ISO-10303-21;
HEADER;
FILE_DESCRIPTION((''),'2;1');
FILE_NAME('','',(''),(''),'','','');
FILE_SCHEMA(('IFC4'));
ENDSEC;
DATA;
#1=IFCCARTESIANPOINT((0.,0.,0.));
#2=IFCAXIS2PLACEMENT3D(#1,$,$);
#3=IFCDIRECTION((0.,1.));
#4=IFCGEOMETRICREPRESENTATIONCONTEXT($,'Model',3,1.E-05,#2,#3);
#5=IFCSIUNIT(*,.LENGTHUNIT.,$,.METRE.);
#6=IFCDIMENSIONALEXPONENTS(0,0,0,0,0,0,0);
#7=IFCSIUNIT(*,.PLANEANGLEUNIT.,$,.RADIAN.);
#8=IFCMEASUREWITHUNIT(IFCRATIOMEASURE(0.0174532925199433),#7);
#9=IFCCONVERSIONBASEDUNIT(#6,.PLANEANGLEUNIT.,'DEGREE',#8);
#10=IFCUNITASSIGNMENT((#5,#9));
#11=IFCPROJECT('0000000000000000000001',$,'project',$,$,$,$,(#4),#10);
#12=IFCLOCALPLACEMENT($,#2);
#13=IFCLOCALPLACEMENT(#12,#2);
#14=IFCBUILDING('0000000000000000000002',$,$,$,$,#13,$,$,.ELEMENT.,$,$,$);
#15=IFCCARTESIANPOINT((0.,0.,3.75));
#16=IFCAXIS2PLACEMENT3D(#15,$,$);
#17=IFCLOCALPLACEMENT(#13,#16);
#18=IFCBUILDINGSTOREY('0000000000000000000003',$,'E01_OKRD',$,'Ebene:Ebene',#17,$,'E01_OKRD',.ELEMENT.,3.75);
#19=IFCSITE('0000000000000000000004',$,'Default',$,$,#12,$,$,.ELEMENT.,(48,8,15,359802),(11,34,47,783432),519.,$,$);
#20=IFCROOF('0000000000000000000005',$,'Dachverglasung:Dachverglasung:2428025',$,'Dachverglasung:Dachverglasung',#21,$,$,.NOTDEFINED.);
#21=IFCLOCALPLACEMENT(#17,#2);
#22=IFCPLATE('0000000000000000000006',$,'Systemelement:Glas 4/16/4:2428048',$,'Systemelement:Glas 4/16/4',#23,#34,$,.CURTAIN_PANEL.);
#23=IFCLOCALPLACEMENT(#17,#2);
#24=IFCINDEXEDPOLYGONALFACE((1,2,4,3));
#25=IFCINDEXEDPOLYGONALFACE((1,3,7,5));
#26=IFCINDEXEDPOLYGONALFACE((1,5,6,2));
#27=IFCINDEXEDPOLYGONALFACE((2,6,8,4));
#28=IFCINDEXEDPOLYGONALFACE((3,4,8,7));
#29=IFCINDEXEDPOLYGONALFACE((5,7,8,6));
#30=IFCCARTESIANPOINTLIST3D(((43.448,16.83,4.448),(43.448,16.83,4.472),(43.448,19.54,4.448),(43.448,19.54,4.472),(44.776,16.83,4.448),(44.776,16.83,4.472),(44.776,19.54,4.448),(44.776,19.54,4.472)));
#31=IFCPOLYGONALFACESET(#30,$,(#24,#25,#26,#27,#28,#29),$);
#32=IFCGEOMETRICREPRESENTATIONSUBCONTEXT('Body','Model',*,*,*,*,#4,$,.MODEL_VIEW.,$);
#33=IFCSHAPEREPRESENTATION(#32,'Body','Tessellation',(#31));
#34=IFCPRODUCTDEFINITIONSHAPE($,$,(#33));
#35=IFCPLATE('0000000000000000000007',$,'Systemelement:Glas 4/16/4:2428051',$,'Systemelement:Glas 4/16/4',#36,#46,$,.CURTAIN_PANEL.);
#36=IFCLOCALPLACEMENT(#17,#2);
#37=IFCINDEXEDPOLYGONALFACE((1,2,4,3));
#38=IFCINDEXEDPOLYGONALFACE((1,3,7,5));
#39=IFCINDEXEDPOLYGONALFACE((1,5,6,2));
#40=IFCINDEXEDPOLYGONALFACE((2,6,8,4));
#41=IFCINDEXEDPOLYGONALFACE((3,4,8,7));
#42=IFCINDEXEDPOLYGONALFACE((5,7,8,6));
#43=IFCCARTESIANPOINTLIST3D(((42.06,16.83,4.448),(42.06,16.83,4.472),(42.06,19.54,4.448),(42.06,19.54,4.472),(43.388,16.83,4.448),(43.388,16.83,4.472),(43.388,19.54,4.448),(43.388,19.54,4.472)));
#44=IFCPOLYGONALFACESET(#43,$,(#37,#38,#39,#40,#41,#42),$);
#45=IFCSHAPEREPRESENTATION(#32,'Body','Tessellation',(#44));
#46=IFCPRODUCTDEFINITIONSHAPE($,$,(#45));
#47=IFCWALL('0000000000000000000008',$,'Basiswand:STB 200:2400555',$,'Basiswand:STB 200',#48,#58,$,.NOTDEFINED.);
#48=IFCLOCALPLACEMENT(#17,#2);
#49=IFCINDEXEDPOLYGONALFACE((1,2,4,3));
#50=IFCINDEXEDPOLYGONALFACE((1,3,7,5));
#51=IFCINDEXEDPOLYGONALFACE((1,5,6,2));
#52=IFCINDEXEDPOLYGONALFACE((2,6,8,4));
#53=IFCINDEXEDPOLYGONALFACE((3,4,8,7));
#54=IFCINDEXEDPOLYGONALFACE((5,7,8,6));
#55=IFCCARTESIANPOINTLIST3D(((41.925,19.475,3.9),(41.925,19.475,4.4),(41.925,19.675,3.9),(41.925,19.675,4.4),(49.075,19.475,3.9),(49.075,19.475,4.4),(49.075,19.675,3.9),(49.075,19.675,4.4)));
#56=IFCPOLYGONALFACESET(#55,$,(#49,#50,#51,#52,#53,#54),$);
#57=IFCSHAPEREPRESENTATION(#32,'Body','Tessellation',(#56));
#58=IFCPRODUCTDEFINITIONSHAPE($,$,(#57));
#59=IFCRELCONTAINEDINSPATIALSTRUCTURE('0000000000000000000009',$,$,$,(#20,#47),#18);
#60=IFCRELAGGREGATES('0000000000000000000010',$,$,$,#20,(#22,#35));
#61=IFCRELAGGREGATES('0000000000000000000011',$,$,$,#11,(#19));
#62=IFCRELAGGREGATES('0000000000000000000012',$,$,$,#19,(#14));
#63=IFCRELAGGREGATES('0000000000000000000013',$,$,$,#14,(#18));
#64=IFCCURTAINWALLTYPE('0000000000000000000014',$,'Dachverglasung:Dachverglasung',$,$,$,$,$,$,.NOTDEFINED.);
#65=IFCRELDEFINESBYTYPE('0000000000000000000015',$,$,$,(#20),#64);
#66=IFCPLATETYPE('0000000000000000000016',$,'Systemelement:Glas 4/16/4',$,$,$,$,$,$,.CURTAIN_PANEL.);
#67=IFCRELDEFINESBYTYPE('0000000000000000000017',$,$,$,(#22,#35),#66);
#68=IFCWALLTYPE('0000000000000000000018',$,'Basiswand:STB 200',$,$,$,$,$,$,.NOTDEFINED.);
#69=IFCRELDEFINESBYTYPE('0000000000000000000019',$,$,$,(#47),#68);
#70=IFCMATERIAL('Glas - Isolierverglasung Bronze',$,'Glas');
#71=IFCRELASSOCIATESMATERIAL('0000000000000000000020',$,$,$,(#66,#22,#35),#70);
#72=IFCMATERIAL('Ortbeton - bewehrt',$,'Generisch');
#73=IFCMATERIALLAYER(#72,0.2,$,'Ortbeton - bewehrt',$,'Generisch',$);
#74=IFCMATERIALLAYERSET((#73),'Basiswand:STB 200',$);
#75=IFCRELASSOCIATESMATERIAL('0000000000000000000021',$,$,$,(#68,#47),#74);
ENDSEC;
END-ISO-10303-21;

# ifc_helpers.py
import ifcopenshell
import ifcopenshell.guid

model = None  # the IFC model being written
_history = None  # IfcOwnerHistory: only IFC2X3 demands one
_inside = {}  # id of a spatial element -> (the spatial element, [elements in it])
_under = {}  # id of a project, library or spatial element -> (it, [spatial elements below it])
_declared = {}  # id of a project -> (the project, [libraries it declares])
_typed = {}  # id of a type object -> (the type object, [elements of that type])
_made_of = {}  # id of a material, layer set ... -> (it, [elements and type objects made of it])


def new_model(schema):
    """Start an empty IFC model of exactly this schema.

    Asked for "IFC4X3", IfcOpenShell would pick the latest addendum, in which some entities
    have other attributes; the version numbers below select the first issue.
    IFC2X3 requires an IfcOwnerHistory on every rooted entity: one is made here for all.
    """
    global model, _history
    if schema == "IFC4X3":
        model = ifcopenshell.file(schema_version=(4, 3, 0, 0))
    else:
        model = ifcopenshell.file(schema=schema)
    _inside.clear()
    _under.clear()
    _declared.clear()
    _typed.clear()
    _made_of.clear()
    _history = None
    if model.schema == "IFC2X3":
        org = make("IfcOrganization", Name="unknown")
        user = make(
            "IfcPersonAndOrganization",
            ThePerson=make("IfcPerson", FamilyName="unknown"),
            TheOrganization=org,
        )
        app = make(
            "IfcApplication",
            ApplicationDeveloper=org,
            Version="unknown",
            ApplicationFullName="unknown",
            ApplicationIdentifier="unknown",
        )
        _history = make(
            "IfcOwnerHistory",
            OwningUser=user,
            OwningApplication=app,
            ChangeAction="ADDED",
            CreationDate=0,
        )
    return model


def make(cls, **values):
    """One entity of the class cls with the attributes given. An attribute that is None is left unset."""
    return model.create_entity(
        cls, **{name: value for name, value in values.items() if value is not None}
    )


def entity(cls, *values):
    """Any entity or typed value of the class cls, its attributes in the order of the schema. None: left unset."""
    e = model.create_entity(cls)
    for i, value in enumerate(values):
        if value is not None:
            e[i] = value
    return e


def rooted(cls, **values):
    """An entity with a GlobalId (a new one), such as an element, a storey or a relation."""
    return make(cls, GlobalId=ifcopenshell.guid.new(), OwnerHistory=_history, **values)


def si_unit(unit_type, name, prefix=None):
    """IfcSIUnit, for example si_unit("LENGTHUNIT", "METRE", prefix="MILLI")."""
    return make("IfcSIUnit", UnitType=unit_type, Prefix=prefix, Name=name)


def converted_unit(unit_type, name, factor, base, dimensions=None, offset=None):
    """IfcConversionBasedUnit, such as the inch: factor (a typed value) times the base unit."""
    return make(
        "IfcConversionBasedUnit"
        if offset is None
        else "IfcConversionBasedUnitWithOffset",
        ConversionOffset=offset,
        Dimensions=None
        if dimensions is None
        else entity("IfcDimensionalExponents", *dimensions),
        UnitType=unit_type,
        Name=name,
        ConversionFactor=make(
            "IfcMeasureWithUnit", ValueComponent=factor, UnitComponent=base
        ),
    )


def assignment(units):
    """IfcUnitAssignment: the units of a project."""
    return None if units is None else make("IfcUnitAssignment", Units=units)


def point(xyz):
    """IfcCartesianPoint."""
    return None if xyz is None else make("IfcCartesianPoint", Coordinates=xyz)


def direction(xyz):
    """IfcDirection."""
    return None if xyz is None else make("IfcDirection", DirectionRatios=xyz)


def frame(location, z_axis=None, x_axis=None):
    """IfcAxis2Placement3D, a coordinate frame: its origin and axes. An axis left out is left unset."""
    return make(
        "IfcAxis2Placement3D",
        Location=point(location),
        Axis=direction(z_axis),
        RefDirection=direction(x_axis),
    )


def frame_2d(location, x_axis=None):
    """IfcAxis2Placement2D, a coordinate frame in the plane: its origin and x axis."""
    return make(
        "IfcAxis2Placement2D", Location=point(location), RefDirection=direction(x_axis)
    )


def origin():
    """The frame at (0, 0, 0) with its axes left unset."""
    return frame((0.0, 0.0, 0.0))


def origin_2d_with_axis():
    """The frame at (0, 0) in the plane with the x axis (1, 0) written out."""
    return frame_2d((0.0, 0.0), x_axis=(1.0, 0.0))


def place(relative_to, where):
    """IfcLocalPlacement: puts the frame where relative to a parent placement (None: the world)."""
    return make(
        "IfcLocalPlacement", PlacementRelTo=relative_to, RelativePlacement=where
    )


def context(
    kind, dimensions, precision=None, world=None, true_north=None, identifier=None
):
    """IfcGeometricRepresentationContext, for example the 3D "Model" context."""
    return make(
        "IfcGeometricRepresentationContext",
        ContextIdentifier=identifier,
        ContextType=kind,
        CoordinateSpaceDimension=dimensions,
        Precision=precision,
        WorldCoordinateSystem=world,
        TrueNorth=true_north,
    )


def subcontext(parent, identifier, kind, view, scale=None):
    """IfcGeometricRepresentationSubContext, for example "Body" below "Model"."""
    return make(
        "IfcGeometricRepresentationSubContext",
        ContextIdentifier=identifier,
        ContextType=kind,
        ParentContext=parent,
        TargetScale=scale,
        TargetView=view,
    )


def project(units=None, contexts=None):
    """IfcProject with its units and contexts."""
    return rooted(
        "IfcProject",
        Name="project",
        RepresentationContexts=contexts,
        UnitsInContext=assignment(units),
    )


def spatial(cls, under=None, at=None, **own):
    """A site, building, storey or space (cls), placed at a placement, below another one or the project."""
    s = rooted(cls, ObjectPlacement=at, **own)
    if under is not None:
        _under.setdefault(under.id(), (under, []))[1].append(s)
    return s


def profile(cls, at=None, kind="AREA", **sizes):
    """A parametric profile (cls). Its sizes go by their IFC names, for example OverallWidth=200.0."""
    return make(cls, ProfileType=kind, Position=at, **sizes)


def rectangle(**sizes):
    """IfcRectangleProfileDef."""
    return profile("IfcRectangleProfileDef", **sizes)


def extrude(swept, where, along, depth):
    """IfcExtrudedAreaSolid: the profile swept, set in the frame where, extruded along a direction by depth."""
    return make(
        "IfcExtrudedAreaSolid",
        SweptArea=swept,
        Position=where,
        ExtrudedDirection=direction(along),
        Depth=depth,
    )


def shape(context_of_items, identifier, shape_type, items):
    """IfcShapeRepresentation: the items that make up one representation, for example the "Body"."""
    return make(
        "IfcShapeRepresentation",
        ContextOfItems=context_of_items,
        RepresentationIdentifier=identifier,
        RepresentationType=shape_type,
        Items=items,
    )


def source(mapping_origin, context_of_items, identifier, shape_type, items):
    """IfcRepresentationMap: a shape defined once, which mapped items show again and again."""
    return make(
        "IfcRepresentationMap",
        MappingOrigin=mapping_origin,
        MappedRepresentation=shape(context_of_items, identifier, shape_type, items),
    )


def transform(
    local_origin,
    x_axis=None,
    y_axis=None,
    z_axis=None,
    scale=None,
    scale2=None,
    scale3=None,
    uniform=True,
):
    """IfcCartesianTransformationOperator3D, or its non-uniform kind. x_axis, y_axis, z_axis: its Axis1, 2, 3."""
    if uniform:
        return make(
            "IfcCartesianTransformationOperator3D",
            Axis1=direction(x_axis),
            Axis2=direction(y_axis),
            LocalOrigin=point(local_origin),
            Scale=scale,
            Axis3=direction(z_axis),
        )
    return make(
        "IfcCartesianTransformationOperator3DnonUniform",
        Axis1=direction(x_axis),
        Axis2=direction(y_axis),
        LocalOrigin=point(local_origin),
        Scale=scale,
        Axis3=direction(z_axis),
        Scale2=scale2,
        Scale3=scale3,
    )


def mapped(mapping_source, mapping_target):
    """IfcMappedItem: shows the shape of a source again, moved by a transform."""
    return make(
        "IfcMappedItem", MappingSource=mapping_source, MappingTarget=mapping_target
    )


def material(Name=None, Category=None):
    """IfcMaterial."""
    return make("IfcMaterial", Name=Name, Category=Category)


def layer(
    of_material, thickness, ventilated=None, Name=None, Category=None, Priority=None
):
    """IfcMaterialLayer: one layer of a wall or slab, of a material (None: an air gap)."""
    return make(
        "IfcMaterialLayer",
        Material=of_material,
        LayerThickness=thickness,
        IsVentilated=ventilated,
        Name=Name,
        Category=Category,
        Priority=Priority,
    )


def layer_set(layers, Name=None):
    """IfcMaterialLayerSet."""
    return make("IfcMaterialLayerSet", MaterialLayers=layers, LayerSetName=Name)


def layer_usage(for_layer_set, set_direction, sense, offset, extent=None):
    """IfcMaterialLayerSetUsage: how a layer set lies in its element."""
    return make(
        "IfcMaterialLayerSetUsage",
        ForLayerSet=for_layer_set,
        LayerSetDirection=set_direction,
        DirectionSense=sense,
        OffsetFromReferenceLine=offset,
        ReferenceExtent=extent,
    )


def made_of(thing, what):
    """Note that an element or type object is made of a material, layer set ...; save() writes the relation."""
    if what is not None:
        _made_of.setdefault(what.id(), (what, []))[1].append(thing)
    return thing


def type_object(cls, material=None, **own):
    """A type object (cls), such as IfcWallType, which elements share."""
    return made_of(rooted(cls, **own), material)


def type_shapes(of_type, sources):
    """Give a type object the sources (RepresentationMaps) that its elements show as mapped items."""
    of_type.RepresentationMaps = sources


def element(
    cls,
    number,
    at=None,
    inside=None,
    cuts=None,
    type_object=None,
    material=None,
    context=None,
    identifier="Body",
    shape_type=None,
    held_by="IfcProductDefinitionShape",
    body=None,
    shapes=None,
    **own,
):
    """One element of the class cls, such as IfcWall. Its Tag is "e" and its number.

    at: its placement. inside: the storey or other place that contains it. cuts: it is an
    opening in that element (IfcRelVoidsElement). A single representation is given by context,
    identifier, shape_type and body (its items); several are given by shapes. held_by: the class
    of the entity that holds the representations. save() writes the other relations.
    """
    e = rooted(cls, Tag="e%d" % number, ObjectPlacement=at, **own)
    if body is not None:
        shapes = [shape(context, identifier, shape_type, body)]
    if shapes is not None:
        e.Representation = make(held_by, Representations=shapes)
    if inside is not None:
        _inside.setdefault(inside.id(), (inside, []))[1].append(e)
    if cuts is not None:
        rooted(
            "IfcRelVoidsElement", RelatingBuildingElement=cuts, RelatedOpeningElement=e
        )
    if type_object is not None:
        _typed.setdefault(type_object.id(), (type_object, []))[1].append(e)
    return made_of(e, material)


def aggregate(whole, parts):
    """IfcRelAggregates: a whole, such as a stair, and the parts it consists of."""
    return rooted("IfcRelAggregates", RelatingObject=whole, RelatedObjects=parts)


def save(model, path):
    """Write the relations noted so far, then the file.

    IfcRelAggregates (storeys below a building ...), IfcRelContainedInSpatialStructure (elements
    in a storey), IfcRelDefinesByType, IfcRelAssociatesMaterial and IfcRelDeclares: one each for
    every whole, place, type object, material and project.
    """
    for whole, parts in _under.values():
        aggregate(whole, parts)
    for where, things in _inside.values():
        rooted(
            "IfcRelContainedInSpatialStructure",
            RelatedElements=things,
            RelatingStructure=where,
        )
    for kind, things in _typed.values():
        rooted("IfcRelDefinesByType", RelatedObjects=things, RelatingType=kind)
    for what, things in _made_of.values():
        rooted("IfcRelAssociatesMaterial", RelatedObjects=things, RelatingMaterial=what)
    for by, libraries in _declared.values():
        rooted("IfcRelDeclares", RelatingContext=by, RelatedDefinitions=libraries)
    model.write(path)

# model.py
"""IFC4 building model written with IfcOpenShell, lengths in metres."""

from ifc_helpers import new_model, entity, si_unit, converted_unit, direction, frame, frame_2d, origin, origin_2d_with_axis, place, context, subcontext, project, spatial, rectangle, extrude, shape, source, transform, mapped, material, layer, layer_set, layer_usage, type_object, type_shapes, element, aggregate, save


model = new_model("IFC4")

# Units and contexts
model_context = context("Model", 3, precision=1e-05, world=origin(), true_north=direction((0.0, 1.0)))
body_context = subcontext(model_context, "Body", "Model", "MODEL_VIEW")
footprint_context = subcontext(model_context, "FootPrint", "Model", "MODEL_VIEW")
ifc_project = project(units=[si_unit("LENGTHUNIT", "METRE"), converted_unit("PLANEANGLEUNIT", "DEGREE", entity("IfcRatioMeasure", 0.0174532925199433), si_unit("PLANEANGLEUNIT", "RADIAN"), dimensions=[0, 0, 0, 0, 0, 0, 0])], contexts=[model_context])

# Site, building, storey
site_placement = place(None, frame((0.0, 0.0, 0.0)))
site = spatial("IfcSite", under=ifc_project, at=site_placement, Name="Default", CompositionType="ELEMENT", RefLatitude=(48, 8, 15, 359802), RefLongitude=(11, 34, 47, 783432), RefElevation=519.0)
building_placement = place(site_placement, origin())
building = spatial("IfcBuilding", under=site, at=building_placement, CompositionType="ELEMENT")
storey_placement = place(building_placement, frame((0.0, 0.0, 3.75)))
storey = spatial("IfcBuildingStorey", under=building, at=storey_placement, Name="E01_OKRD", ObjectType="Ebene:Ebene", LongName="E01_OKRD", CompositionType="ELEMENT", Elevation=3.75)

# Shared definitions
ifc_material_1 = material(Name="Ortbeton - bewehrt", Category="Generisch")

# Roof, plates
curtain_wall_type = type_object("IfcCurtainWallType", Name="Dachverglasung:Dachverglasung", PredefinedType="NOTDEFINED")
roof_placement = place(storey_placement, frame((0.0, 0.0, -3.75)))
roof = element("IfcRoof", 1, at=roof_placement, inside=storey, type_object=curtain_wall_type, Name="Dachverglasung:Dachverglasung:2428025", ObjectType="Dachverglasung:Dachverglasung", PredefinedType="NOTDEFINED")
ifc_material_2 = material(Name="Glas - Isolierverglasung Bronze", Category="Glas")
plate_type = type_object("IfcPlateType", Name="Systemelement:Glas 4/16/4", PredefinedType="CURTAIN_PANEL", material=ifc_material_2)
shared_shape_1 = source(origin(), body_context, "Body", "SweptSolid", [
    extrude(rectangle(XDim=0.024, YDim=2.71, at=origin_2d_with_axis()), frame((0.0, 0.0, 0.0), z_axis=(0.0, 0.0, 1.0), x_axis=(0.0, 1.0, 0.0)), (0.0, 0.0, 1.0), 1.328),
])
cartesian_point = entity("IfcCartesianPoint", [1.355, -0.012])
shared_shape_2 = source(origin(), footprint_context, "FootPrint", "Curve2D", [
    entity("IfcPolyline", [cartesian_point, entity("IfcCartesianPoint", [1.355, 0.012]), entity("IfcCartesianPoint", [-1.355, 0.012]), entity("IfcCartesianPoint", [-1.355, -0.012]), cartesian_point]),
])
type_shapes(plate_type, [shared_shape_1, shared_shape_2])
plate_1_placement = place(roof_placement, frame((44.776, 18.185, 8.21), z_axis=(-1.0, 0.0, 0.0), x_axis=(0.0, 1.0, 0.0)))
plate_1 = element("IfcPlate", 2, at=plate_1_placement, type_object=plate_type, material=ifc_material_2, Name="Systemelement:Glas 4/16/4:2428048", ObjectType="Systemelement:Glas 4/16/4", PredefinedType="CURTAIN_PANEL", shapes=[
    shape(body_context, "Body", "MappedRepresentation", [mapped(shared_shape_1, transform((0.0, 0.0, 0.0), scale=1.0))]),
    shape(body_context, "Body", "MappedRepresentation", [mapped(shared_shape_2, transform((0.0, 0.0, 0.0), scale=1.0))]),
])
plate_2_placement = place(roof_placement, frame((43.388, 18.185, 8.21), z_axis=(-1.0, 0.0, 0.0), x_axis=(0.0, 1.0, 0.0)))
plate_2 = element("IfcPlate", 3, at=plate_2_placement, type_object=plate_type, material=ifc_material_2, Name="Systemelement:Glas 4/16/4:2428051", ObjectType="Systemelement:Glas 4/16/4", PredefinedType="CURTAIN_PANEL", shapes=[
    shape(body_context, "Body", "MappedRepresentation", [mapped(shared_shape_1, transform((0.0, 0.0, 0.0), scale=1.0))]),
    shape(body_context, "Body", "MappedRepresentation", [mapped(shared_shape_2, transform((0.0, 0.0, 0.0), scale=1.0))]),
])
aggregate(roof, [plate_1, plate_2])

# Wall
ifc_layer = layer(ifc_material_1, 0.2, Name="Ortbeton - bewehrt", Category="Generisch")
ifc_layer_set = layer_set([ifc_layer], Name="Basiswand:STB 200")
ifc_layer_usage = layer_usage(ifc_layer_set, "AXIS2", "NEGATIVE", 0.1)
wall_type = type_object("IfcWallType", Name="Basiswand:STB 200", PredefinedType="NOTDEFINED", material=ifc_layer_set)
wall_placement = place(storey_placement, frame((41.925, 19.575, 3.9)))
element("IfcWall", 4, at=wall_placement, inside=storey, type_object=wall_type, material=ifc_layer_usage, Name="Basiswand:STB 200:2400555", ObjectType="Basiswand:STB 200", PredefinedType="NOTDEFINED", context=body_context, shape_type="SweptSolid", body=[
    extrude(rectangle(XDim=7.15, YDim=0.2, at=frame_2d((3.575, 0.0), x_axis=(-1.0, 0.0))), origin(), (0.0, 0.0, 1.0), 0.5),
])

save(model, "model.ifc")
